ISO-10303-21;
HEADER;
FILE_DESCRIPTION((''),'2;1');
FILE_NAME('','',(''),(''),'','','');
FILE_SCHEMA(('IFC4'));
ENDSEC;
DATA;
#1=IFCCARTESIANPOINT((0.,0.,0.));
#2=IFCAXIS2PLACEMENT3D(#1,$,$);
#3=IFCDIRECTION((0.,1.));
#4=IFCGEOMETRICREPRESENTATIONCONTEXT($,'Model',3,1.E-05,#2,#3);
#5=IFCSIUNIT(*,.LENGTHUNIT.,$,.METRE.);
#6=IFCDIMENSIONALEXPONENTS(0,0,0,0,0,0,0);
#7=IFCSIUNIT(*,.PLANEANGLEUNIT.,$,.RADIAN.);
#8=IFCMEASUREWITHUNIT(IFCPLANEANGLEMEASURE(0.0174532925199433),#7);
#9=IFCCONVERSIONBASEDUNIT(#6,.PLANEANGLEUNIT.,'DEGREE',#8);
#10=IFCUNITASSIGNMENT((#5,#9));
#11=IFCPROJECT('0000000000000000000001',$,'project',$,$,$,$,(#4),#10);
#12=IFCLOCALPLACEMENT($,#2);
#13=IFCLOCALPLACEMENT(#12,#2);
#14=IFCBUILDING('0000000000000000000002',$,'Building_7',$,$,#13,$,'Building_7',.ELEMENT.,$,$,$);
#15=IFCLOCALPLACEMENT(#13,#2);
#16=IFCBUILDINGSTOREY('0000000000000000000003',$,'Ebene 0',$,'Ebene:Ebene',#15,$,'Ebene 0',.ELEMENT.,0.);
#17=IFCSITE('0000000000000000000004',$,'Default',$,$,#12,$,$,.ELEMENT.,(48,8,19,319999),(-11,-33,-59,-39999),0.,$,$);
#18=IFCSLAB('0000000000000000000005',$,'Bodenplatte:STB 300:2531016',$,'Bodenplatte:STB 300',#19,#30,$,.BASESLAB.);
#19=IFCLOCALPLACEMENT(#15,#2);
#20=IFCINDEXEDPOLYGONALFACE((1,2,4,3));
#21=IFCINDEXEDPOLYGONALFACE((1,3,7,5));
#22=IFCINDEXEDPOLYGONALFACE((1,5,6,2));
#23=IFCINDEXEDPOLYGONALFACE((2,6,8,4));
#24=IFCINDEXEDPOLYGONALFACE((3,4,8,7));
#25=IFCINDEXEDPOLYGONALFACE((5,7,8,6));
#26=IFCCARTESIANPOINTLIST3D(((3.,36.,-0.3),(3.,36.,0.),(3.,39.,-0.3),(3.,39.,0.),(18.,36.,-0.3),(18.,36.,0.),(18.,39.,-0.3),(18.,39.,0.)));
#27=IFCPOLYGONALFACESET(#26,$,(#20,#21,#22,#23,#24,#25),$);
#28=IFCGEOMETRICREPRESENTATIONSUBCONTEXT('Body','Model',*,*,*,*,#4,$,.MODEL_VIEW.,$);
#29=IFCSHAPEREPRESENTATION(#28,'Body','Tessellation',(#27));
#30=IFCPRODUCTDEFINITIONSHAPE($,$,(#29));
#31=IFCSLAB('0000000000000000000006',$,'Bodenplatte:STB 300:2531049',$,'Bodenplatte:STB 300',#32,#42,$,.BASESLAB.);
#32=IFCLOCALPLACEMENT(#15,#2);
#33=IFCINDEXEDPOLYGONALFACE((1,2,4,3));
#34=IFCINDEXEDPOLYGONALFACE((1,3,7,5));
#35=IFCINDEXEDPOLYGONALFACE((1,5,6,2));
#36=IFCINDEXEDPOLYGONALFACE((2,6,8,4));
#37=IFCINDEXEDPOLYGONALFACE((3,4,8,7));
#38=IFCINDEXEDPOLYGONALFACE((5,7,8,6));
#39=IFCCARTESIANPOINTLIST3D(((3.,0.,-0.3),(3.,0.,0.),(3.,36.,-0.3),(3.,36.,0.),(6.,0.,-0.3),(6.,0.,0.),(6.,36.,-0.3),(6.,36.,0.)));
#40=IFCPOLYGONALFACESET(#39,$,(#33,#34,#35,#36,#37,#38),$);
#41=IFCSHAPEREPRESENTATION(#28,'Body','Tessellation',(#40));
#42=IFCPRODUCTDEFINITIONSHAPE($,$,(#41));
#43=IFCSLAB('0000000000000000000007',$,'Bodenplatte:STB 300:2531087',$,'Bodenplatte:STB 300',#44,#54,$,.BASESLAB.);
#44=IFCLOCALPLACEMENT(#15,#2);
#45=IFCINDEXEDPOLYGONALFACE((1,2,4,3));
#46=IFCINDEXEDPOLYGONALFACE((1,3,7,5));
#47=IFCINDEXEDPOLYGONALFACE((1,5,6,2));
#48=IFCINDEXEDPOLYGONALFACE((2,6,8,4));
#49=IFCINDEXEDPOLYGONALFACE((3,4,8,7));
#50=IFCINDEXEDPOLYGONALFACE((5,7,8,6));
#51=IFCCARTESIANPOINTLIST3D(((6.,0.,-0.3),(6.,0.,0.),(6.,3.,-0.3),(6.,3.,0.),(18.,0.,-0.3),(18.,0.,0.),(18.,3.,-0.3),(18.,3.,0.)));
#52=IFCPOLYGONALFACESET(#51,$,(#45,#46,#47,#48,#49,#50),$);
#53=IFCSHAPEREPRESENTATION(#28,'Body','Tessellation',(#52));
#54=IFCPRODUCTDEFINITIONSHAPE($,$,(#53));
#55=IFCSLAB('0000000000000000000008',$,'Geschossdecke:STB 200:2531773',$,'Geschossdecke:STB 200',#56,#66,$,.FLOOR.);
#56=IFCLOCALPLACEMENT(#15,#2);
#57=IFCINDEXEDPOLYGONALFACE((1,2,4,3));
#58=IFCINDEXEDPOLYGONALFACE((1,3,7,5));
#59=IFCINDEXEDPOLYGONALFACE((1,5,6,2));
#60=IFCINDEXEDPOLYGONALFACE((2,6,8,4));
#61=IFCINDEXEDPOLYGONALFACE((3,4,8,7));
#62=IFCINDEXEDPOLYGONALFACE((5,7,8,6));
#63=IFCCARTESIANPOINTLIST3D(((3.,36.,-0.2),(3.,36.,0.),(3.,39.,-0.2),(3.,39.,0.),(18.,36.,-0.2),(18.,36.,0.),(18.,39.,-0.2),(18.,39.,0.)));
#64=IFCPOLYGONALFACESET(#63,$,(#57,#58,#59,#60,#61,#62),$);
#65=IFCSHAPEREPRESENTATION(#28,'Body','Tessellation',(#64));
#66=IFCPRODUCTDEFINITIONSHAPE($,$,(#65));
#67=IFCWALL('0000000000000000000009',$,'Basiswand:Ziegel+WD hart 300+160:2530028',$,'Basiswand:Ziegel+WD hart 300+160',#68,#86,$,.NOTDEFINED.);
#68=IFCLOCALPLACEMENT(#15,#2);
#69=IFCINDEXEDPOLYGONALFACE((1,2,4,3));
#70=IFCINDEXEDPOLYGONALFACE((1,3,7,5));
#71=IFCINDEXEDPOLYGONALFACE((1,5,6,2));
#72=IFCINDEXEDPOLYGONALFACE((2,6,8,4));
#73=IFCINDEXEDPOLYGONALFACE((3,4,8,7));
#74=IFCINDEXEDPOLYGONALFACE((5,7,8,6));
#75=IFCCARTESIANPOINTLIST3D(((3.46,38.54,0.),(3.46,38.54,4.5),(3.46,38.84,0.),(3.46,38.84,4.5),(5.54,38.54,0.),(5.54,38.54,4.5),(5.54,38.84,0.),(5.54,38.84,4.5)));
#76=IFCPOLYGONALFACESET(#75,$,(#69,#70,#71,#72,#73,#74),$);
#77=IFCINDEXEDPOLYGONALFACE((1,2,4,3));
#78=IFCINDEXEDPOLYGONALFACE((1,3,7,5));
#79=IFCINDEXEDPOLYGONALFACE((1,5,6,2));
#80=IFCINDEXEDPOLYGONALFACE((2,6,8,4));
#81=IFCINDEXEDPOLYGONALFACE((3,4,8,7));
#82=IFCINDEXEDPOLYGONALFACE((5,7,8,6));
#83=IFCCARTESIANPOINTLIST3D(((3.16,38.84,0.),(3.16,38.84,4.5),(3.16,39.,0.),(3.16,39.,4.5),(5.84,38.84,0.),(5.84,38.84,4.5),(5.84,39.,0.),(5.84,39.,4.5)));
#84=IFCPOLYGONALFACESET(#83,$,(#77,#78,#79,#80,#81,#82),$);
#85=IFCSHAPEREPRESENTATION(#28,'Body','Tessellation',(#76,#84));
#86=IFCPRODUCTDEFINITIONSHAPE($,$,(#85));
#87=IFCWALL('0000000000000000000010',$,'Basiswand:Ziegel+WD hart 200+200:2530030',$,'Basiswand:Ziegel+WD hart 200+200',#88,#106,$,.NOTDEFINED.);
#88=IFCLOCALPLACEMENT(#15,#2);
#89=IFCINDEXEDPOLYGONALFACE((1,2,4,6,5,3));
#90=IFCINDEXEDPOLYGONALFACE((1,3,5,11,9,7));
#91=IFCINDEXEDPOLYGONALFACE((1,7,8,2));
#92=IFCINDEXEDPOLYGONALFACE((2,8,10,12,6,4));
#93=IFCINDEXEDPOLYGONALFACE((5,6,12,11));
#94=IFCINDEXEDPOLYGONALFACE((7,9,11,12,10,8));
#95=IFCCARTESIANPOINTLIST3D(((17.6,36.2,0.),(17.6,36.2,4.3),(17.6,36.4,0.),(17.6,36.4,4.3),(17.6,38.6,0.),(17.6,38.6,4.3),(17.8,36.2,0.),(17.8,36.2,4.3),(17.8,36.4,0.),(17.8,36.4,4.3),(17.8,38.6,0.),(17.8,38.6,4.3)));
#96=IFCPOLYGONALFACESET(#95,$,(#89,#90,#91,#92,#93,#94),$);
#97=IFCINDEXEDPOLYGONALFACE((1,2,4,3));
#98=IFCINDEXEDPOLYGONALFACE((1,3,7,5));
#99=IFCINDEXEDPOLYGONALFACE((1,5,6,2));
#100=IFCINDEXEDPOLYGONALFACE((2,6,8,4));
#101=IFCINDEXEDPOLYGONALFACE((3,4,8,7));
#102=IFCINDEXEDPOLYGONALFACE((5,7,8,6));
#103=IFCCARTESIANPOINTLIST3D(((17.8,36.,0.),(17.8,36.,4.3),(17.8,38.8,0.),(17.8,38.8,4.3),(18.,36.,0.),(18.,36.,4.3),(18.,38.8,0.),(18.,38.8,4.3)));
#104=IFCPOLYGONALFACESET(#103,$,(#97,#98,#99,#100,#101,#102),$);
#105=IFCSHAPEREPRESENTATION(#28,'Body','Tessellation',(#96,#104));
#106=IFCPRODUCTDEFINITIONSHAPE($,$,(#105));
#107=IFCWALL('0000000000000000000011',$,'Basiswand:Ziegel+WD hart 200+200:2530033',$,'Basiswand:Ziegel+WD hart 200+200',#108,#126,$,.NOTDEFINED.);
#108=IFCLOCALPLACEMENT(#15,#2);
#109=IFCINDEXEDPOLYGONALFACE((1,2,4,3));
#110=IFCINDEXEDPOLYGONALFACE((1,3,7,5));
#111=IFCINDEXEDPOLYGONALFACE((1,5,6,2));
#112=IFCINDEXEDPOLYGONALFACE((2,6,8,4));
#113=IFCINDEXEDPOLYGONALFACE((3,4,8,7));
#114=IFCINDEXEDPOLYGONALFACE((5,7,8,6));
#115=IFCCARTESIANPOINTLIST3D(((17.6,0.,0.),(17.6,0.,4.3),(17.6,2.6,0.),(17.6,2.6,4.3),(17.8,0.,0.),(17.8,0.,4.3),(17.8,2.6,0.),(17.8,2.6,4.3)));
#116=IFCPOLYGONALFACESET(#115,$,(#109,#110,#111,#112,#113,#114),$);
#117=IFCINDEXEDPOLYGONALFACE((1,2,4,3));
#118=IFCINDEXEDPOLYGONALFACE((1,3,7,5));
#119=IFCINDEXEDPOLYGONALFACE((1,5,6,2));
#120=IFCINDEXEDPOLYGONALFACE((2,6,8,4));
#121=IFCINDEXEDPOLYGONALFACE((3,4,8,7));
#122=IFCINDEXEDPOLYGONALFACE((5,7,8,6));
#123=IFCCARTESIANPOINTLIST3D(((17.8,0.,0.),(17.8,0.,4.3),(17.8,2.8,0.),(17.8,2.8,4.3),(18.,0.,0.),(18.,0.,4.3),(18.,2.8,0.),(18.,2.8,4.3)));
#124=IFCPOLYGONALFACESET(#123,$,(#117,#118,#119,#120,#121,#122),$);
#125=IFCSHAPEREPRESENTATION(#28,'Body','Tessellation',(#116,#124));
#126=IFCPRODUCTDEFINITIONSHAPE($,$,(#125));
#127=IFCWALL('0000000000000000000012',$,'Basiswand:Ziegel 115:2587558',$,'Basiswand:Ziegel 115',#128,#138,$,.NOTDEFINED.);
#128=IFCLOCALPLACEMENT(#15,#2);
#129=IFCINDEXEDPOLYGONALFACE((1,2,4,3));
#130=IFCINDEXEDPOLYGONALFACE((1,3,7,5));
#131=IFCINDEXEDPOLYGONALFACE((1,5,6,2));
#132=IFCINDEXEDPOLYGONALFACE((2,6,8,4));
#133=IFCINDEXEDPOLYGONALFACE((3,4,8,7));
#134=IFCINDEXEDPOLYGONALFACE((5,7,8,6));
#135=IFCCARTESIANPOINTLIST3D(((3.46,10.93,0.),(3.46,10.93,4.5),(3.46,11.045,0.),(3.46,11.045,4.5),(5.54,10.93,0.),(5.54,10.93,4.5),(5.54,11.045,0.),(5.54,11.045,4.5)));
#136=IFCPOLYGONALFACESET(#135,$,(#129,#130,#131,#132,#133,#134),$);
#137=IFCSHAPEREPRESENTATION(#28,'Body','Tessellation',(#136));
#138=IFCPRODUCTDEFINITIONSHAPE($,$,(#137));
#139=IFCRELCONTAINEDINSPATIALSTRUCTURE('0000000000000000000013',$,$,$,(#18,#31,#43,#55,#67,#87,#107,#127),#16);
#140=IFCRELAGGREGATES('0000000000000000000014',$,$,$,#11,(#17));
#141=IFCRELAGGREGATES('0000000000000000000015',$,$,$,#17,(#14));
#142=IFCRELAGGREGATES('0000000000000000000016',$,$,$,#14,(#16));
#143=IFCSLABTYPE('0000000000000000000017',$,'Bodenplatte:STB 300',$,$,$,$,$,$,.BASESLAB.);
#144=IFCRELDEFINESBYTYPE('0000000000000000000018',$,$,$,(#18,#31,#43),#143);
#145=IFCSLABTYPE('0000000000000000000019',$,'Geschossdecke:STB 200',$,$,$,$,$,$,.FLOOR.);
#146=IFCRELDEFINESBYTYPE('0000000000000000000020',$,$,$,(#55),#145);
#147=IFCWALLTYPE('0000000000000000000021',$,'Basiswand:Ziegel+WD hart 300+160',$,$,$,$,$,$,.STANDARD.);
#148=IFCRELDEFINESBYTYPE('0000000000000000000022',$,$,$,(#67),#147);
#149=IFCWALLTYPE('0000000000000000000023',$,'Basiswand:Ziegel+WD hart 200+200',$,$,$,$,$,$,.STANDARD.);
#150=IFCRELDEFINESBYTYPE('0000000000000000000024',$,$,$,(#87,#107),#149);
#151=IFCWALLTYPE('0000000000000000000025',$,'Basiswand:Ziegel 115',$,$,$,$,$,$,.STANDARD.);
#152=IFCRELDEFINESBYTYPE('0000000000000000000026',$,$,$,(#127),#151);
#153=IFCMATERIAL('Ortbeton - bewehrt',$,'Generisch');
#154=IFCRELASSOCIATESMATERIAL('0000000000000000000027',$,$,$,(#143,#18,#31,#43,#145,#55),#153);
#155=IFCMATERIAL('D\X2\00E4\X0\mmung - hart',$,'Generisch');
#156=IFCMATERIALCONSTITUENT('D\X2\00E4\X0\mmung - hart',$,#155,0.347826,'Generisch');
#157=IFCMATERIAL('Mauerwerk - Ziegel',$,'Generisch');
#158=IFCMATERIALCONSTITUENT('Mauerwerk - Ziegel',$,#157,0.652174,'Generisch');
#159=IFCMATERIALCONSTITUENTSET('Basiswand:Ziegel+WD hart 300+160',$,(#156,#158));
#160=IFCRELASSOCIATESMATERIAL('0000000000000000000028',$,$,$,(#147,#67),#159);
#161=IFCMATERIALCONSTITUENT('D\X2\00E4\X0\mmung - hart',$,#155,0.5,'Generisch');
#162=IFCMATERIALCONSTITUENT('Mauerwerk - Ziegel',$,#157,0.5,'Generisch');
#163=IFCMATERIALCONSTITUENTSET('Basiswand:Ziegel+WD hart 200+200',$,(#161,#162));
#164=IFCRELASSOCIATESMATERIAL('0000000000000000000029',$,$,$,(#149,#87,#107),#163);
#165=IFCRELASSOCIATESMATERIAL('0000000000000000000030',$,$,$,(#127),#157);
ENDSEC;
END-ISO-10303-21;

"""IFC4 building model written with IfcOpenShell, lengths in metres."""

from ifc_helpers import new_model, entity, si_unit, converted_unit, direction, frame, origin, place, context, subcontext, project, spatial, indexed_curve, outline, extrude, material, constituent, constituent_set, type_object, element, save


model = new_model("IFC4")

# Units and contexts
model_context = context("Model", 3, precision=1e-05, world=origin(), true_north=direction((0.0, 1.0)))
body_context = subcontext(model_context, "Body", "Model", "MODEL_VIEW")
ifc_project = project(units=[si_unit("LENGTHUNIT", "METRE"), converted_unit("PLANEANGLEUNIT", "DEGREE", entity("IfcPlaneAngleMeasure", 0.0174532925199433), si_unit("PLANEANGLEUNIT", "RADIAN"), dimensions=[0, 0, 0, 0, 0, 0, 0])], contexts=[model_context])

# Site, building, storey
site_placement = place(None, origin())
site = spatial("IfcSite", under=ifc_project, at=site_placement, Name="Default", CompositionType="ELEMENT", RefLatitude=(48, 8, 19, 319999), RefLongitude=(-11, -33, -59, -39999), RefElevation=0.0)
building_placement = place(site_placement, origin())
building = spatial("IfcBuilding", under=site, at=building_placement, Name="Building_7", LongName="Building_7", CompositionType="ELEMENT")
storey_placement = place(building_placement, origin())
storey = spatial("IfcBuildingStorey", under=building, at=storey_placement, Name="Ebene 0", ObjectType="Ebene:Ebene", LongName="Ebene 0", CompositionType="ELEMENT", Elevation=0.0)

# Slabs
ifc_material_1 = material(Name="Ortbeton - bewehrt", Category="Generisch")
slab_type_1 = type_object("IfcSlabType", Name="Bodenplatte:STB 300", PredefinedType="BASESLAB", material=ifc_material_1)
slab_1_placement = place(storey_placement, origin())
element("IfcSlab", 1, at=slab_1_placement, inside=storey, type_object=slab_type_1, material=ifc_material_1, Name="Bodenplatte:STB 300:2531016", ObjectType="Bodenplatte:STB 300", PredefinedType="BASESLAB", context=body_context, shape_type="SweptSolid", body=[
    extrude(outline(indexed_curve([(-1.5, -7.5), (1.5, -7.5), (1.5, 7.5), (-1.5, 7.5), (-1.5, -7.5)], self_intersect=False)), frame((10.5, 37.5, 0.0), z_axis=(0.0, 0.0, -1.0), x_axis=(0.0, 1.0, 0.0)), (0.0, 0.0, 1.0), 0.3),
])
slab_2_placement = place(storey_placement, origin())
element("IfcSlab", 2, at=slab_2_placement, inside=storey, type_object=slab_type_1, material=ifc_material_1, Name="Bodenplatte:STB 300:2531049", ObjectType="Bodenplatte:STB 300", PredefinedType="BASESLAB", context=body_context, shape_type="SweptSolid", body=[
    extrude(outline(indexed_curve([(-18.0, -1.5), (18.0, -1.5), (18.0, 1.5), (-18.0, 1.5), (-18.0, -1.5)], self_intersect=False)), frame((4.5, 18.0, 0.0), z_axis=(0.0, 0.0, -1.0), x_axis=(0.0, 1.0, 0.0)), (0.0, 0.0, 1.0), 0.3),
])
slab_3_placement = place(storey_placement, origin())
element("IfcSlab", 3, at=slab_3_placement, inside=storey, type_object=slab_type_1, material=ifc_material_1, Name="Bodenplatte:STB 300:2531087", ObjectType="Bodenplatte:STB 300", PredefinedType="BASESLAB", context=body_context, shape_type="SweptSolid", body=[
    extrude(outline(indexed_curve([(-1.5, -6.0), (1.5, -6.0), (1.5, 6.0), (-1.5, 6.0), (-1.5, -6.0)], self_intersect=False)), frame((12.0, 1.5, 0.0), z_axis=(0.0, 0.0, -1.0), x_axis=(0.0, 1.0, 0.0)), (0.0, 0.0, 1.0), 0.3),
])
slab_type_2 = type_object("IfcSlabType", Name="Geschossdecke:STB 200", PredefinedType="FLOOR", material=ifc_material_1)
slab_4_placement = place(storey_placement, origin())
element("IfcSlab", 4, at=slab_4_placement, inside=storey, type_object=slab_type_2, material=ifc_material_1, Name="Geschossdecke:STB 200:2531773", ObjectType="Geschossdecke:STB 200", PredefinedType="FLOOR", context=body_context, shape_type="SweptSolid", body=[
    extrude(outline(indexed_curve([(-1.5, -7.5), (1.5, -7.5), (1.5, 7.5), (-1.5, 7.5), (-1.5, -7.5)], self_intersect=False)), frame((10.5, 37.5, 0.0), z_axis=(0.0, 0.0, -1.0), x_axis=(0.0, 1.0, 0.0)), (0.0, 0.0, 1.0), 0.2),
])

# Walls
ifc_material_2 = material(Name="Dämmung - hart", Category="Generisch")
ifc_constituent_1 = constituent(ifc_material_2, Name="Dämmung - hart", Category="Generisch", fraction=0.347826)
ifc_material_3 = material(Name="Mauerwerk - Ziegel", Category="Generisch")
ifc_constituent_2 = constituent(ifc_material_3, Name="Mauerwerk - Ziegel", Category="Generisch", fraction=0.652174)
ifc_constituent_set_1 = constituent_set(constituents=[ifc_constituent_1, ifc_constituent_2], Name="Basiswand:Ziegel+WD hart 300+160")
wall_type_1 = type_object("IfcWallType", Name="Basiswand:Ziegel+WD hart 300+160", PredefinedType="STANDARD", material=ifc_constituent_set_1)
wall_1_placement = place(storey_placement, frame((3.46, 38.77, 0.0)))
element("IfcWall", 5, at=wall_1_placement, inside=storey, type_object=wall_type_1, material=ifc_constituent_set_1, Name="Basiswand:Ziegel+WD hart 300+160:2530028", ObjectType="Basiswand:Ziegel+WD hart 300+160", PredefinedType="NOTDEFINED", context=body_context, shape_type="SweptSolid", body=[
    extrude(outline(indexed_curve([(-0.15, -1.04), (0.15, -1.04), (0.15, 1.04), (-0.15, 1.04), (-0.15, -1.04)], self_intersect=False)), frame((1.04, -0.08, 0.0), z_axis=(0.0, 0.0, 1.0), x_axis=(0.0, 1.0, 0.0)), (0.0, 0.0, 1.0), 4.5),
    extrude(outline(indexed_curve([(-0.08, -1.34), (0.08, -1.34), (0.08, 1.34), (-0.08, 1.34), (-0.08, -1.34)], self_intersect=False)), frame((1.04, 0.15, 0.0), z_axis=(0.0, 0.0, 1.0), x_axis=(0.0, -1.0, 0.0)), (0.0, 0.0, 1.0), 4.5),
])
ifc_constituent_3 = constituent(ifc_material_2, Name="Dämmung - hart", Category="Generisch", fraction=0.5)
ifc_constituent_4 = constituent(ifc_material_3, Name="Mauerwerk - Ziegel", Category="Generisch", fraction=0.5)
ifc_constituent_set_2 = constituent_set(constituents=[ifc_constituent_3, ifc_constituent_4], Name="Basiswand:Ziegel+WD hart 200+200")
wall_type_2 = type_object("IfcWallType", Name="Basiswand:Ziegel+WD hart 200+200", PredefinedType="STANDARD", material=ifc_constituent_set_2)
wall_2_placement = place(storey_placement, frame((17.8, 38.6, 0.0), z_axis=(0.0, 0.0, 1.0), x_axis=(0.0, -1.0, 0.0)))
element("IfcWall", 6, at=wall_2_placement, inside=storey, type_object=wall_type_2, material=ifc_constituent_set_2, Name="Basiswand:Ziegel+WD hart 200+200:2530030", ObjectType="Basiswand:Ziegel+WD hart 200+200", PredefinedType="NOTDEFINED", context=body_context, shape_type="SweptSolid", body=[
    extrude(outline(indexed_curve([(-2.15, -1.5333), (2.15, -1.5333), (2.15, 0.6667), (2.15, 0.8667), (-2.15, 0.8667), (-2.15, 0.6667), (-2.15, -1.5333)], self_intersect=False)), frame((1.5333, -0.2, 2.15), z_axis=(0.0, 1.0, 0.0), x_axis=(0.0, 0.0, 1.0)), (0.0, 0.0, 1.0), 0.2),
    extrude(outline(indexed_curve([(-2.15, -1.4), (2.15, -1.4), (2.15, 1.4), (-2.15, 1.4), (-2.15, -1.4)], self_intersect=False)), frame((1.2, 0.0, 2.15), z_axis=(0.0, 1.0, 0.0), x_axis=(0.0, 0.0, 1.0)), (0.0, 0.0, 1.0), 0.2),
])
wall_3_placement = place(storey_placement, frame((17.8, 2.6, 0.0), z_axis=(0.0, 0.0, 1.0), x_axis=(0.0, -1.0, 0.0)))
element("IfcWall", 7, at=wall_3_placement, inside=storey, type_object=wall_type_2, material=ifc_constituent_set_2, Name="Basiswand:Ziegel+WD hart 200+200:2530033", ObjectType="Basiswand:Ziegel+WD hart 200+200", PredefinedType="NOTDEFINED", context=body_context, shape_type="SweptSolid", body=[
    extrude(outline(indexed_curve([(-2.15, -1.3), (2.15, -1.3), (2.15, 1.3), (-2.15, 1.3), (-2.15, -1.3)], self_intersect=False)), frame((1.3, -0.2, 2.15), z_axis=(0.0, 1.0, 0.0), x_axis=(0.0, 0.0, 1.0)), (0.0, 0.0, 1.0), 0.2),
    extrude(outline(indexed_curve([(-2.15, -1.4), (2.15, -1.4), (2.15, 1.4), (-2.15, 1.4), (-2.15, -1.4)], self_intersect=False)), frame((1.2, 0.0, 2.15), z_axis=(0.0, 1.0, 0.0), x_axis=(0.0, 0.0, 1.0)), (0.0, 0.0, 1.0), 0.2),
])
wall_type_3 = type_object("IfcWallType", Name="Basiswand:Ziegel 115", PredefinedType="STANDARD")
wall_4_placement = place(storey_placement, frame((3.46, 10.9875, 0.0)))
element("IfcWall", 8, at=wall_4_placement, inside=storey, type_object=wall_type_3, material=ifc_material_3, Name="Basiswand:Ziegel 115:2587558", ObjectType="Basiswand:Ziegel 115", PredefinedType="NOTDEFINED", context=body_context, shape_type="SweptSolid", body=[
    extrude(outline(indexed_curve([(2.08, 0.0575), (0.0, 0.0575), (0.0, -0.0575), (2.08, -0.0575), (2.08, 0.0575)], self_intersect=False)), origin(), (0.0, 0.0, 1.0), 4.5),
])

save(model, "model.ifc")
